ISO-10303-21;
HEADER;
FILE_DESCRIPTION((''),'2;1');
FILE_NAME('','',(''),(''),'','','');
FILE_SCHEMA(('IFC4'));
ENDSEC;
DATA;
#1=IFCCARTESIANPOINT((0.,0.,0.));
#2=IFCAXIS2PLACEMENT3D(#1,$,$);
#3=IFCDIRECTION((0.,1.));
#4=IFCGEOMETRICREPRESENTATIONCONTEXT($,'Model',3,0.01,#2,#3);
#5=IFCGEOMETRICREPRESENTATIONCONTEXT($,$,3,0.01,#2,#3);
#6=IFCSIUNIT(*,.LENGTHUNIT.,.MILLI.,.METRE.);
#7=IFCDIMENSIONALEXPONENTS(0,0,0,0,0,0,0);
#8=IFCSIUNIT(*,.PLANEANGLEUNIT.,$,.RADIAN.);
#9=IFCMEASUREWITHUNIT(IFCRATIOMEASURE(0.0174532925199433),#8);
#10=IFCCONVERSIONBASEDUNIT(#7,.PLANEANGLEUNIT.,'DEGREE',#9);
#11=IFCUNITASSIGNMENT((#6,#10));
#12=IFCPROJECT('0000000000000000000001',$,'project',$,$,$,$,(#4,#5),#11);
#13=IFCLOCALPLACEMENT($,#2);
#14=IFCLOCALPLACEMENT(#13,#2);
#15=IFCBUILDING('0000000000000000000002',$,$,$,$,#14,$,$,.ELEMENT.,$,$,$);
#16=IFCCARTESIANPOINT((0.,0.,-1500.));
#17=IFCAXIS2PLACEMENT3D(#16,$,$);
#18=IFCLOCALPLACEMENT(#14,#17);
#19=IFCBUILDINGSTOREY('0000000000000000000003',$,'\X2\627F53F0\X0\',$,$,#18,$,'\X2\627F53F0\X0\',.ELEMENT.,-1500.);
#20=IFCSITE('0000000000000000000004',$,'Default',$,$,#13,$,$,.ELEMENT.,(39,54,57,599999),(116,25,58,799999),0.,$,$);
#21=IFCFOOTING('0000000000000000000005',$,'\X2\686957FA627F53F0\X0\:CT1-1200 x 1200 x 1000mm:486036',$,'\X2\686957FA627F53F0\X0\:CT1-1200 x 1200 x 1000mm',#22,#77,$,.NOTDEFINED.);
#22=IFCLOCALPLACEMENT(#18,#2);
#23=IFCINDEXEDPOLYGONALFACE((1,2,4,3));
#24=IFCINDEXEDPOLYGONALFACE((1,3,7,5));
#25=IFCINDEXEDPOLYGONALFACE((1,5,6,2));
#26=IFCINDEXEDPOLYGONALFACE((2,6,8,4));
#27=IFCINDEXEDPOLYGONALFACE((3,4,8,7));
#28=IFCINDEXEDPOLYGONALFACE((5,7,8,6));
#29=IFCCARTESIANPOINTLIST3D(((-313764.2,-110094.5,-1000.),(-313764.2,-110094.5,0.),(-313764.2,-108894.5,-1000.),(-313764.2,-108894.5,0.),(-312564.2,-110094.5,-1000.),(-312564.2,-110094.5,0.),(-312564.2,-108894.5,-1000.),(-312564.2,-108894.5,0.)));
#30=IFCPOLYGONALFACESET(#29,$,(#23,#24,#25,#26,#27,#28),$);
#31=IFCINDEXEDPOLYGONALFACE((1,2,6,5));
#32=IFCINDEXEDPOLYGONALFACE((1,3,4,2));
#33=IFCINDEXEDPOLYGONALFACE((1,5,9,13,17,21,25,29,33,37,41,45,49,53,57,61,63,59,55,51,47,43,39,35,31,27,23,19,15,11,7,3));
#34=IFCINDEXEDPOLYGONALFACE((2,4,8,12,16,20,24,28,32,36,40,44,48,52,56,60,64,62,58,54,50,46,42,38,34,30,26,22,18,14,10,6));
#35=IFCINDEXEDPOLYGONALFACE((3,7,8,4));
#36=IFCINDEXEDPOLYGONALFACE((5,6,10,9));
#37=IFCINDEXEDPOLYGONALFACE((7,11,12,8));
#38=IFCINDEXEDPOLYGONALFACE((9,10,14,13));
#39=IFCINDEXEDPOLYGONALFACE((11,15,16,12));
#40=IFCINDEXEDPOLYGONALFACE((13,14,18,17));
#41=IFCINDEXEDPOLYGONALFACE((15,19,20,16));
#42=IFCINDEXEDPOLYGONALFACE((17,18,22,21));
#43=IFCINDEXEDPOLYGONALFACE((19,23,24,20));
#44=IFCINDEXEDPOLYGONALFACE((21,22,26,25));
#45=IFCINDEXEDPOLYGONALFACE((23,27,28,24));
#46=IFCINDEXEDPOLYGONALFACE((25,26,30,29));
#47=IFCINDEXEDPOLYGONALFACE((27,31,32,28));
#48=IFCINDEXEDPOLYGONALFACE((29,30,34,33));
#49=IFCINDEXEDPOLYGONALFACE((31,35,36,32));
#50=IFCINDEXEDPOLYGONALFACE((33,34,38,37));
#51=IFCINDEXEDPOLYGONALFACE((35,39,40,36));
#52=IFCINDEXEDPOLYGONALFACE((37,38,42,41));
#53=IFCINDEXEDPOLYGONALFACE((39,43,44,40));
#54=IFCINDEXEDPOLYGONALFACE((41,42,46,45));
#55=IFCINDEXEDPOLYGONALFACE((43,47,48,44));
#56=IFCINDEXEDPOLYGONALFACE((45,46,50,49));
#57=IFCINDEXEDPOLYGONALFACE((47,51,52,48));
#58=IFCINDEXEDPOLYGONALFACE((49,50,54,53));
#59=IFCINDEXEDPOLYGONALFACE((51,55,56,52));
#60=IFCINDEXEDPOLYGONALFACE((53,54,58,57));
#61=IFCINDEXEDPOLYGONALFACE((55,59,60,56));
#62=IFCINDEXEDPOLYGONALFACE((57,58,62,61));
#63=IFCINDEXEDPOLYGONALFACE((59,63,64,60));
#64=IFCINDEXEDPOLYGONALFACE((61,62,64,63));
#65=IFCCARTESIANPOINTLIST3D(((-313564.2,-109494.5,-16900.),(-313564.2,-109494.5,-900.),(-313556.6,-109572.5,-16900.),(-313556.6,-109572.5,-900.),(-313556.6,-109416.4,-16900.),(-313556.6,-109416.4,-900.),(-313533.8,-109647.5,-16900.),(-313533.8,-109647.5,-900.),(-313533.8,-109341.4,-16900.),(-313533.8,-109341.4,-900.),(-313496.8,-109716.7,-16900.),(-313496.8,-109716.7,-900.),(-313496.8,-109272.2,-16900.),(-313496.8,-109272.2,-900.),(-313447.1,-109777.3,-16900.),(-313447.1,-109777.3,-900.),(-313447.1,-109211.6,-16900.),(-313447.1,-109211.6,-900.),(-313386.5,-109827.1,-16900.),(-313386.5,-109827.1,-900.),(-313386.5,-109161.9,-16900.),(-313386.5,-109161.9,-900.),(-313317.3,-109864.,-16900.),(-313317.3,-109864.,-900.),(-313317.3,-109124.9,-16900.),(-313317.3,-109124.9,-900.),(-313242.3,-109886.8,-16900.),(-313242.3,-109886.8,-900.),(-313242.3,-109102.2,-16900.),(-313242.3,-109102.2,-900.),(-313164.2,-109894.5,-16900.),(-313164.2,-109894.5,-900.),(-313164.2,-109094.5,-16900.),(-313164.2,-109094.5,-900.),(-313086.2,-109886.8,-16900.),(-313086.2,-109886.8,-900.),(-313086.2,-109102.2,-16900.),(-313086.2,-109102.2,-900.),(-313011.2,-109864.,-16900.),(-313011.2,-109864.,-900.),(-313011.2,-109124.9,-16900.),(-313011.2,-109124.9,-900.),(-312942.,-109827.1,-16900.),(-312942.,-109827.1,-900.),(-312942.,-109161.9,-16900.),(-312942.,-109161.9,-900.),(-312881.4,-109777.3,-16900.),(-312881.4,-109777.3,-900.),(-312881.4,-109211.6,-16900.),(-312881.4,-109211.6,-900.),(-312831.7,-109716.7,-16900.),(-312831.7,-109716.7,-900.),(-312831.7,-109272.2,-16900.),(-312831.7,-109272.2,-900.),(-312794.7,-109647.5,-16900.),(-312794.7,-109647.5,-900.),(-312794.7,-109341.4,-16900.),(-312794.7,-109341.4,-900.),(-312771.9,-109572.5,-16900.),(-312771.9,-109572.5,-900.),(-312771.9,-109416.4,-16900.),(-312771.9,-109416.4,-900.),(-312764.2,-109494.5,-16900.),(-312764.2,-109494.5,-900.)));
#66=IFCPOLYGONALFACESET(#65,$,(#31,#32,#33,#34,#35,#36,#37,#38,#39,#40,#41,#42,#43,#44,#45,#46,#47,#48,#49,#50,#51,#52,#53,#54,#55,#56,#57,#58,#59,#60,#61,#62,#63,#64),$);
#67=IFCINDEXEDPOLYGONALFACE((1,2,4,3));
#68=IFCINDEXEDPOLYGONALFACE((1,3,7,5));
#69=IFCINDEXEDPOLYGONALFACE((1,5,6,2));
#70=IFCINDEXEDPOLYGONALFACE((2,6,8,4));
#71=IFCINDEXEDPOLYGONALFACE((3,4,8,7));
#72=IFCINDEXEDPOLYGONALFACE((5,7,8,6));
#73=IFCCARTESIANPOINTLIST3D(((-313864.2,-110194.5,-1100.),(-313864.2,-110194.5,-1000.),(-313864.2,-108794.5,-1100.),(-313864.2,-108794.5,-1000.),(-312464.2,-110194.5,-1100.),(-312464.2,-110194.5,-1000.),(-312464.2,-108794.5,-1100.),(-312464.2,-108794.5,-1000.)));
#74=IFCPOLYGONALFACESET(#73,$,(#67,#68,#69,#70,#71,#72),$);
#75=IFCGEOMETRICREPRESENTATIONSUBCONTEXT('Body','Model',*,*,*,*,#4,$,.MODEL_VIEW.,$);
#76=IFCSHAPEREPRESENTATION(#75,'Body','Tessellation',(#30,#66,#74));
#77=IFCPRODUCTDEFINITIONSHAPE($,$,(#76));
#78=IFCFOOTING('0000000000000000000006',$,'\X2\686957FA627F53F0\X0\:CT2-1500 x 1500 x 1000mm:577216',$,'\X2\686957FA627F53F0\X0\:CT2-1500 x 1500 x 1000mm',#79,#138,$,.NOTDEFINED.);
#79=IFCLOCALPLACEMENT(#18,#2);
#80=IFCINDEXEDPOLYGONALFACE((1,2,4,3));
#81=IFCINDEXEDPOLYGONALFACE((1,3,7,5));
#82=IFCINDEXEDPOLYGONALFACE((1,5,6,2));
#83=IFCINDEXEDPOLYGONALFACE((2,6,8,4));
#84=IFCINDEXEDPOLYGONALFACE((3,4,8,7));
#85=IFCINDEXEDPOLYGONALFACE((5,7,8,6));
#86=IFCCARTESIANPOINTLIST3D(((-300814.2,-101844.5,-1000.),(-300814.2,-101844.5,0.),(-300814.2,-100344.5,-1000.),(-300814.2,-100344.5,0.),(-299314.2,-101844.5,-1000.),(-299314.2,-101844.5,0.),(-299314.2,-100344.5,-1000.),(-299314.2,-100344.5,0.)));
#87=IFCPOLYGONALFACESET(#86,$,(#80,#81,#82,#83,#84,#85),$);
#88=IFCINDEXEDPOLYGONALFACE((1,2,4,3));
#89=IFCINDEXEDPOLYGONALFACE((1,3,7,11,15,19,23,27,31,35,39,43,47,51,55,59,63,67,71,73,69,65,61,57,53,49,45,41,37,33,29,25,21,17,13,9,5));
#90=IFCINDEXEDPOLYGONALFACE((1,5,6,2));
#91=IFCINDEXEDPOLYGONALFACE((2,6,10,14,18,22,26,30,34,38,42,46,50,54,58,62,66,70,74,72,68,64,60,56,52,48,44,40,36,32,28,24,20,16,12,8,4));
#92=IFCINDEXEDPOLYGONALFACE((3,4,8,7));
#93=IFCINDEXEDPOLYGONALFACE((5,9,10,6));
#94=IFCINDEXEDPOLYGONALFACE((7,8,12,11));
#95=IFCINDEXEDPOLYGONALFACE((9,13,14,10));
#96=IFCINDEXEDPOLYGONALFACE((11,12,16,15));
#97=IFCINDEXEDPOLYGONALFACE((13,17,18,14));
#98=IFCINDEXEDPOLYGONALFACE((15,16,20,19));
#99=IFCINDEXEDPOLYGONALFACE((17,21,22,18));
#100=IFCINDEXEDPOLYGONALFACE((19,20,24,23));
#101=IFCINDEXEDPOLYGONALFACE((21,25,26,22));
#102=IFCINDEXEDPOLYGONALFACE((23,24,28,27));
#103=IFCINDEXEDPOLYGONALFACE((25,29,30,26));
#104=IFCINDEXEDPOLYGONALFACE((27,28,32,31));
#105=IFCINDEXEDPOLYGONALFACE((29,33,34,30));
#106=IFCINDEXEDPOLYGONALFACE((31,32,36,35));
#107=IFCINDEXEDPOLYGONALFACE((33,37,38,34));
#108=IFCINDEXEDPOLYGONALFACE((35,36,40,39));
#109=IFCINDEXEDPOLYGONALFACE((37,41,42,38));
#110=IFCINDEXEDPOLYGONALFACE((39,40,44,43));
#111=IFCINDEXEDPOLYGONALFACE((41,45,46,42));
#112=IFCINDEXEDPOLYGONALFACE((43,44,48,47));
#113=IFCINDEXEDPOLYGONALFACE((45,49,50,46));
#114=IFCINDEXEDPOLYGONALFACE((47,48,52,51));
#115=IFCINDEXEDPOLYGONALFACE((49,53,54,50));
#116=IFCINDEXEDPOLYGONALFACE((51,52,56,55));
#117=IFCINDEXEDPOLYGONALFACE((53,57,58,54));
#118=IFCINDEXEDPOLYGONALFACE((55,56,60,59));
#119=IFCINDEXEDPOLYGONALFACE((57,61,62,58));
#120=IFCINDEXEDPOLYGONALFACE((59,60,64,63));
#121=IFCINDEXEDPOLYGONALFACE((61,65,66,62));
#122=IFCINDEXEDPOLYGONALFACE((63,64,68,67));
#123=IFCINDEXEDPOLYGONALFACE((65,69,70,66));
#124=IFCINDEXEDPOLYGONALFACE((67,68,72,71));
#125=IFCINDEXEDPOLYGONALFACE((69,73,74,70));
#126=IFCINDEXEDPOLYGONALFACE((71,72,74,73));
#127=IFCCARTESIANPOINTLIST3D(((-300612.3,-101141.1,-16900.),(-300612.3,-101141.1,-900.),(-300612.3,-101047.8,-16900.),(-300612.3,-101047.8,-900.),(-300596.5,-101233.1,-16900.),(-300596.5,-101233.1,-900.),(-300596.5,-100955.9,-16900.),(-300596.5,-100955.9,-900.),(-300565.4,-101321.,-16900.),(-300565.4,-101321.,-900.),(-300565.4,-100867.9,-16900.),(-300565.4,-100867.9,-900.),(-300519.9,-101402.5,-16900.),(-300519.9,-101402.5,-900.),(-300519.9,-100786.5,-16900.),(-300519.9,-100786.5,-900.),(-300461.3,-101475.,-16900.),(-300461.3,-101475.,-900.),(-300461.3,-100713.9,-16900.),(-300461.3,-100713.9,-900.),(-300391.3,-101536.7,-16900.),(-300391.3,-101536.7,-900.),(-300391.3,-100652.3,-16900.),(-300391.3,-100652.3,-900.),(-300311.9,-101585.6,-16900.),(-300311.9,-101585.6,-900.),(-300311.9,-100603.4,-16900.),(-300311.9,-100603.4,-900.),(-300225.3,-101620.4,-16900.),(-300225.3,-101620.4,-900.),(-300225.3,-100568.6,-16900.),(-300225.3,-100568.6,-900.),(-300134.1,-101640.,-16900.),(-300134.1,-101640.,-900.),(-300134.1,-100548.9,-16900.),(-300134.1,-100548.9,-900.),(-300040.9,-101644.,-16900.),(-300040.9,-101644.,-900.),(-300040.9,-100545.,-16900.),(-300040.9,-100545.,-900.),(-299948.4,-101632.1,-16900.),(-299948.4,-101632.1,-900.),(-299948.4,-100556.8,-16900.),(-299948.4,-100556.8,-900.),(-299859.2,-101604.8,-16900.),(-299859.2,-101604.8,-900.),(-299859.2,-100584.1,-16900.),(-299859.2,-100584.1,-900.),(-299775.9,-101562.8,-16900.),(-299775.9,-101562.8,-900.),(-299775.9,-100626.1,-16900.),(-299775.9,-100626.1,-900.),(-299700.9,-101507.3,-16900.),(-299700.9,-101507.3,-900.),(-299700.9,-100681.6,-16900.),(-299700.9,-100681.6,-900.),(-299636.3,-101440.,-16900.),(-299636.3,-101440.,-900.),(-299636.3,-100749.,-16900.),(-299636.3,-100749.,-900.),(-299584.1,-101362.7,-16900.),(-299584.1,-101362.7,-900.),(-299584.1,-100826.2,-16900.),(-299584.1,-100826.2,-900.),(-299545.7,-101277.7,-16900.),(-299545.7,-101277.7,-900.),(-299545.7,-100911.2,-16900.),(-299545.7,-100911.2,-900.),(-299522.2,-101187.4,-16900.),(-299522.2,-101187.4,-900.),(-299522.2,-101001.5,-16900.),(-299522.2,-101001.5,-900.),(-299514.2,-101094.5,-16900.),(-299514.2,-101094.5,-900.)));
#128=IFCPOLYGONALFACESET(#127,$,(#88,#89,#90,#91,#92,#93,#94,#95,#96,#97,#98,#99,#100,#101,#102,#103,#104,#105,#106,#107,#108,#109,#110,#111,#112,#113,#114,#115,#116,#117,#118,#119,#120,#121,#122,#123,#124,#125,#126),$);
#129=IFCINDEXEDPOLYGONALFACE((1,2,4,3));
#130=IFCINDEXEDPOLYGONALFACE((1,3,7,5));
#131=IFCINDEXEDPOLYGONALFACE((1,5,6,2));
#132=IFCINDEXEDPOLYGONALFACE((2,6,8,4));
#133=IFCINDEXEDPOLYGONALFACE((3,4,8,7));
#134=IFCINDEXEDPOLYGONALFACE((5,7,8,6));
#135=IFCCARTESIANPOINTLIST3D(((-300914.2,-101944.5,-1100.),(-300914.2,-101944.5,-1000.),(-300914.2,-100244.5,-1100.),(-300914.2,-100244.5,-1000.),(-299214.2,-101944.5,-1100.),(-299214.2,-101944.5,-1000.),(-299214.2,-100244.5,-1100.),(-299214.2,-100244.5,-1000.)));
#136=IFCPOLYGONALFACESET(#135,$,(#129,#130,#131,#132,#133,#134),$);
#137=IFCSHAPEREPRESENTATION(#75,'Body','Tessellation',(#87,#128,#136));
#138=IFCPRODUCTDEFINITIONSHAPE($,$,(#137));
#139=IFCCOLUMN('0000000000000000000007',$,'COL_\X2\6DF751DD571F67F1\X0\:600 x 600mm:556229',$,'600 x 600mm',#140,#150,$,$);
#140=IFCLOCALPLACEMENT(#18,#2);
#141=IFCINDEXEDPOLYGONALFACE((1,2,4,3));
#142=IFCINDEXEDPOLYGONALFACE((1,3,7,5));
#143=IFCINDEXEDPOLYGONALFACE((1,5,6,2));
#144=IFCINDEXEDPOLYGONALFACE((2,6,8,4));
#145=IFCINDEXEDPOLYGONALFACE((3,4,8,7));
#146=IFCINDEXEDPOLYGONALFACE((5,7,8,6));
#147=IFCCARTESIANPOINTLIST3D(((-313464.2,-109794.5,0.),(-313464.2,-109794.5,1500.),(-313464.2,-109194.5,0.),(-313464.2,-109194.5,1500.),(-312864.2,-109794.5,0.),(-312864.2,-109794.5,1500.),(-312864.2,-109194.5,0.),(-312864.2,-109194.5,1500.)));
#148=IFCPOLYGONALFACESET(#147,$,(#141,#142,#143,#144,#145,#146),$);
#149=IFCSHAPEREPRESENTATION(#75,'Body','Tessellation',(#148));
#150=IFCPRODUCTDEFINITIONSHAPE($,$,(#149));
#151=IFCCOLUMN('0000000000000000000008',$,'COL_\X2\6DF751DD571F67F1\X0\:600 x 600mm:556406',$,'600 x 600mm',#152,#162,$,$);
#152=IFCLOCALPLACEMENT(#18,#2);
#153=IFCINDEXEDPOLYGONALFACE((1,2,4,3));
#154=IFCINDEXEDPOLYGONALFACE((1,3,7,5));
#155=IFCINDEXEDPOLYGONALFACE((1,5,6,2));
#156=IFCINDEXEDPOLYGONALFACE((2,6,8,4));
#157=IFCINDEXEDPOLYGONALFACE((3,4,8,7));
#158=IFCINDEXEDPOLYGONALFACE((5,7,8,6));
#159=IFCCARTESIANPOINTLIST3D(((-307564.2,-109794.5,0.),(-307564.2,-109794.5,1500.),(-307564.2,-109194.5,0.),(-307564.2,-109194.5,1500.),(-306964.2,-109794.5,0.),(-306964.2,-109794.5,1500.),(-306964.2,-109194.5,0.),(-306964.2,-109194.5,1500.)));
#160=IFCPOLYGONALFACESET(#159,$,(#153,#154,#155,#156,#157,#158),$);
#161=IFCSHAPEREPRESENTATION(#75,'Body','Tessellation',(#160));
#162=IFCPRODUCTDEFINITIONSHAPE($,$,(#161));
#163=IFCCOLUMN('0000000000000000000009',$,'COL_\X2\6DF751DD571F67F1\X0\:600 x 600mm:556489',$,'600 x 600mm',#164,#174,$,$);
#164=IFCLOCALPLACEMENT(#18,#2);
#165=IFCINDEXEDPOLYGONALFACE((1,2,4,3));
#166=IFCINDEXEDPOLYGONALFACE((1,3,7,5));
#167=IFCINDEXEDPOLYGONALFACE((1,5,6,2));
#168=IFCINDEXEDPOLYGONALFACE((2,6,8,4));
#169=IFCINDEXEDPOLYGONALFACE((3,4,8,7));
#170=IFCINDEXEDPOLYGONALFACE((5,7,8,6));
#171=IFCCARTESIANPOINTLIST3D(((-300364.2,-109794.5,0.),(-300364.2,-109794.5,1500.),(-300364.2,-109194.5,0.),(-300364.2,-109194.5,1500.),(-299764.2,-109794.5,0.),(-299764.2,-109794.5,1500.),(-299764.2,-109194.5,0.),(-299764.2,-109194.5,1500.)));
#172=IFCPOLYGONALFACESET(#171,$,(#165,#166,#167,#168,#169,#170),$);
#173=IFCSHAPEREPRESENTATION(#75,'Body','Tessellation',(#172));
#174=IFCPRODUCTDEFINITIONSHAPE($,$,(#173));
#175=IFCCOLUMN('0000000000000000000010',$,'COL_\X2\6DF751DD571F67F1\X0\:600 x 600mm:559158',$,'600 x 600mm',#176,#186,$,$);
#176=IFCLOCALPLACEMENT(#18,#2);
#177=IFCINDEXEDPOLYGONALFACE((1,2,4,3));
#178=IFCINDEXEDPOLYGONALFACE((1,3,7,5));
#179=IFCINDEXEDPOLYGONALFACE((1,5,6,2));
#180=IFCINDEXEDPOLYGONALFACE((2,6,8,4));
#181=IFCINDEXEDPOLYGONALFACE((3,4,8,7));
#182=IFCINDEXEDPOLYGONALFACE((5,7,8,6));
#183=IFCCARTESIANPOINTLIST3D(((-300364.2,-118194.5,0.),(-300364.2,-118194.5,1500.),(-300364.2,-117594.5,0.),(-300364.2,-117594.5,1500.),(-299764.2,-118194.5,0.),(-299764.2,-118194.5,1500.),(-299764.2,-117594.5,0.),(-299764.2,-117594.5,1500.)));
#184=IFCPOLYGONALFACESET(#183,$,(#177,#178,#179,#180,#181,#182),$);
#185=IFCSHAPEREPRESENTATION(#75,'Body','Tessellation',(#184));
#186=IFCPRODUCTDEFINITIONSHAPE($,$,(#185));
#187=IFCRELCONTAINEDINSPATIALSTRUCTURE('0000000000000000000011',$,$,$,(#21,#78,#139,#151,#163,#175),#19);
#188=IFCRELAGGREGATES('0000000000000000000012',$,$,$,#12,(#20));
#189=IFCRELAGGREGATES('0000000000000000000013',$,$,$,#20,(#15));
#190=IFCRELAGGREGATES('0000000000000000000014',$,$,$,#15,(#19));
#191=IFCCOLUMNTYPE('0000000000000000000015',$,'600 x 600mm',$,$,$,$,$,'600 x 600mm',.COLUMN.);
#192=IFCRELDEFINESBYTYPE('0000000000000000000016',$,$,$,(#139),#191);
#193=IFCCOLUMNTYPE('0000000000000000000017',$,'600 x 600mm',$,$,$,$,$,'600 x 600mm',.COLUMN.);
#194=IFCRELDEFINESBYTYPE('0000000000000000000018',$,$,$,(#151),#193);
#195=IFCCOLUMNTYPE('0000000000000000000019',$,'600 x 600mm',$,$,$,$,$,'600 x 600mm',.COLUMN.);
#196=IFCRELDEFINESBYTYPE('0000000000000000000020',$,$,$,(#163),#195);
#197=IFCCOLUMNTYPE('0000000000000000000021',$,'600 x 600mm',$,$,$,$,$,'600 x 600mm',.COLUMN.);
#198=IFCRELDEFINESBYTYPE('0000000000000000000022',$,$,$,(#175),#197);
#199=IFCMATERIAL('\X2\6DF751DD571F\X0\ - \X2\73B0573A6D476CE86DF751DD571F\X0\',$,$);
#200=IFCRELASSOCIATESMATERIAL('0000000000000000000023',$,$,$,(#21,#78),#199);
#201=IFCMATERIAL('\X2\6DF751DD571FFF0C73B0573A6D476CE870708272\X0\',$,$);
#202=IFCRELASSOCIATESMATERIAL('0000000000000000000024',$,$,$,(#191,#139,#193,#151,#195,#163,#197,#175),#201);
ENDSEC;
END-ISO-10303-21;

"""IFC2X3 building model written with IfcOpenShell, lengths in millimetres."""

from ifc_helpers import new_model, entity, si_unit, converted_unit, direction, frame, frame_2d, origin, origin_2d_with_axis, place, context, subcontext, project, spatial, rectangle, circle, extrude, source, transform, mapped, material, type_object, type_shapes, element, save


model = new_model("IFC2X3")

# Units and contexts
model_context = context("Model", 3, precision=0.01, world=origin(), true_north=direction((0.0, 1.0)))
context_of_model = context(None, 3, precision=0.01, world=origin(), true_north=direction((0.0, 1.0)))
body_context = subcontext(model_context, "Body", "Model", "MODEL_VIEW")
ifc_project = project(units=[si_unit("LENGTHUNIT", "METRE", prefix="MILLI"), converted_unit("PLANEANGLEUNIT", "DEGREE", entity("IfcRatioMeasure", 0.0174532925199433), si_unit("PLANEANGLEUNIT", "RADIAN"), dimensions=[0, 0, 0, 0, 0, 0, 0])], contexts=[model_context, context_of_model])

# Site, building, storey
site_placement = place(None, origin())
site = spatial("IfcSite", under=ifc_project, at=site_placement, Name="Default", CompositionType="ELEMENT", RefLatitude=(39, 54, 57, 599999), RefLongitude=(116, 25, 58, 799999), RefElevation=0.0)
building_placement = place(site_placement, origin())
building = spatial("IfcBuilding", under=site, at=building_placement, CompositionType="ELEMENT")
storey_placement = place(building_placement, frame((0.0, 0.0, -1500.0)))
storey = spatial("IfcBuildingStorey", under=building, at=storey_placement, Name="承台", LongName="承台", CompositionType="ELEMENT", Elevation=-1500.0)

# Footings
ifc_material_1 = material(Name="混凝土 - 现场浇注混凝土")
footing_1_placement = place(storey_placement, frame((-313864.2, -110194.5, -16900.0)))
element("IfcFooting", 1, at=footing_1_placement, inside=storey, material=ifc_material_1, Name="桩基承台:CT1-1200 x 1200 x 1000mm:486036", ObjectType="桩基承台:CT1-1200 x 1200 x 1000mm", PredefinedType="NOTDEFINED", context=body_context, shape_type="SweptSolid", body=[
    extrude(rectangle(XDim=1200.0, YDim=1200.0, at=origin_2d_with_axis()), frame((700.0, 700.0, 15900.0), z_axis=(0.0, 0.0, 1.0), x_axis=(-1.0, 0.0, 0.0)), (0.0, 0.0, 1.0), 1000.0),
    extrude(circle(Radius=400.0, at=origin_2d_with_axis()), frame((700.0, 700.0, 0.0)), (0.0, 0.0, 1.0), 16000.0),
    extrude(rectangle(XDim=1400.0, YDim=1400.0, at=frame_2d((0.0, 0.0), x_axis=(1.0, 0.0))), frame((700.0, 700.0, 15800.0), z_axis=(0.0, 0.0, 1.0), x_axis=(0.0, 1.0, 0.0)), (0.0, 0.0, 1.0), 100.0),
])
footing_2_placement = place(storey_placement, frame((-300914.2, -101944.5, -16900.0)))
element("IfcFooting", 2, at=footing_2_placement, inside=storey, material=ifc_material_1, Name="桩基承台:CT2-1500 x 1500 x 1000mm:577216", ObjectType="桩基承台:CT2-1500 x 1500 x 1000mm", PredefinedType="NOTDEFINED", context=body_context, shape_type="SweptSolid", body=[
    extrude(rectangle(XDim=1500.0, YDim=1500.0, at=origin_2d_with_axis()), frame((850.0, 850.0, 15900.0), z_axis=(0.0, 0.0, 1.0), x_axis=(-1.0, 0.0, 0.0)), (0.0, 0.0, 1.0), 1000.0),
    extrude(circle(Radius=550.0, at=origin_2d_with_axis()), frame((850.0, 850.0, 0.0)), (0.0, 0.0, 1.0), 16000.0),
    extrude(rectangle(XDim=1700.0, YDim=1700.0, at=frame_2d((0.0, 0.0), x_axis=(1.0, 0.0))), frame((850.0, 850.0, 15800.0), z_axis=(0.0, 0.0, 1.0), x_axis=(0.0, 1.0, 0.0)), (0.0, 0.0, 1.0), 100.0),
])

# Columns
ifc_material_2 = material(Name="混凝土，现场浇注灰色")
column_type_1 = type_object("IfcColumnType", Name="600 x 600mm", ElementType="600 x 600mm", PredefinedType="COLUMN", material=ifc_material_2)
shared_shape_1 = source(origin(), body_context, "Body", "SweptSolid", [
    extrude(rectangle(XDim=600.0, YDim=600.0, at=origin_2d_with_axis()), frame((300.0, 300.0, 0.0), z_axis=(0.0, 0.0, 1.0), x_axis=(-1.0, 0.0, 0.0)), (0.0, 0.0, 1.0), 1500.0),
])
type_shapes(column_type_1, [shared_shape_1])
column_1_placement = place(storey_placement, frame((-313464.2, -109794.5, 0.0)))
element("IfcColumn", 3, at=column_1_placement, inside=storey, type_object=column_type_1, material=ifc_material_2, Name="COL_混凝土柱:600 x 600mm:556229", ObjectType="600 x 600mm", context=body_context, shape_type="MappedRepresentation", body=[
    mapped(shared_shape_1, transform((0.0, 0.0, 0.0), scale=1.0)),
])
column_type_2 = type_object("IfcColumnType", Name="600 x 600mm", ElementType="600 x 600mm", PredefinedType="COLUMN", material=ifc_material_2)
shared_shape_2 = source(origin(), body_context, "Body", "SweptSolid", [
    extrude(rectangle(XDim=600.0, YDim=600.0, at=origin_2d_with_axis()), frame((300.0, 300.0, 0.0), z_axis=(0.0, 0.0, 1.0), x_axis=(-1.0, 0.0, 0.0)), (0.0, 0.0, 1.0), 1500.0),
])
type_shapes(column_type_2, [shared_shape_2])
column_2_placement = place(storey_placement, frame((-307564.2, -109794.5, 0.0)))
element("IfcColumn", 4, at=column_2_placement, inside=storey, type_object=column_type_2, material=ifc_material_2, Name="COL_混凝土柱:600 x 600mm:556406", ObjectType="600 x 600mm", context=body_context, shape_type="MappedRepresentation", body=[
    mapped(shared_shape_2, transform((0.0, 0.0, 0.0), scale=1.0)),
])
column_type_3 = type_object("IfcColumnType", Name="600 x 600mm", ElementType="600 x 600mm", PredefinedType="COLUMN", material=ifc_material_2)
shared_shape_3 = source(origin(), body_context, "Body", "SweptSolid", [
    extrude(rectangle(XDim=600.0, YDim=600.0, at=origin_2d_with_axis()), frame((300.0, 300.0, 0.0), z_axis=(0.0, 0.0, 1.0), x_axis=(-1.0, 0.0, 0.0)), (0.0, 0.0, 1.0), 1500.0),
])
type_shapes(column_type_3, [shared_shape_3])
column_3_placement = place(storey_placement, frame((-300364.2, -109794.5, 0.0)))
element("IfcColumn", 5, at=column_3_placement, inside=storey, type_object=column_type_3, material=ifc_material_2, Name="COL_混凝土柱:600 x 600mm:556489", ObjectType="600 x 600mm", context=body_context, shape_type="MappedRepresentation", body=[
    mapped(shared_shape_3, transform((0.0, 0.0, 0.0), scale=1.0)),
])
column_type_4 = type_object("IfcColumnType", Name="600 x 600mm", ElementType="600 x 600mm", PredefinedType="COLUMN", material=ifc_material_2)
shared_shape_4 = source(origin(), body_context, "Body", "SweptSolid", [
    extrude(rectangle(XDim=600.0, YDim=600.0, at=origin_2d_with_axis()), frame((300.0, 300.0, 0.0), z_axis=(0.0, 0.0, 1.0), x_axis=(-1.0, 0.0, 0.0)), (0.0, 0.0, 1.0), 1500.0),
])
type_shapes(column_type_4, [shared_shape_4])
column_4_placement = place(storey_placement, frame((-300364.2, -118194.5, 0.0)))
element("IfcColumn", 6, at=column_4_placement, inside=storey, type_object=column_type_4, material=ifc_material_2, Name="COL_混凝土柱:600 x 600mm:559158", ObjectType="600 x 600mm", context=body_context, shape_type="MappedRepresentation", body=[
    mapped(shared_shape_4, transform((0.0, 0.0, 0.0), scale=1.0)),
])

save(model, "model.ifc")
